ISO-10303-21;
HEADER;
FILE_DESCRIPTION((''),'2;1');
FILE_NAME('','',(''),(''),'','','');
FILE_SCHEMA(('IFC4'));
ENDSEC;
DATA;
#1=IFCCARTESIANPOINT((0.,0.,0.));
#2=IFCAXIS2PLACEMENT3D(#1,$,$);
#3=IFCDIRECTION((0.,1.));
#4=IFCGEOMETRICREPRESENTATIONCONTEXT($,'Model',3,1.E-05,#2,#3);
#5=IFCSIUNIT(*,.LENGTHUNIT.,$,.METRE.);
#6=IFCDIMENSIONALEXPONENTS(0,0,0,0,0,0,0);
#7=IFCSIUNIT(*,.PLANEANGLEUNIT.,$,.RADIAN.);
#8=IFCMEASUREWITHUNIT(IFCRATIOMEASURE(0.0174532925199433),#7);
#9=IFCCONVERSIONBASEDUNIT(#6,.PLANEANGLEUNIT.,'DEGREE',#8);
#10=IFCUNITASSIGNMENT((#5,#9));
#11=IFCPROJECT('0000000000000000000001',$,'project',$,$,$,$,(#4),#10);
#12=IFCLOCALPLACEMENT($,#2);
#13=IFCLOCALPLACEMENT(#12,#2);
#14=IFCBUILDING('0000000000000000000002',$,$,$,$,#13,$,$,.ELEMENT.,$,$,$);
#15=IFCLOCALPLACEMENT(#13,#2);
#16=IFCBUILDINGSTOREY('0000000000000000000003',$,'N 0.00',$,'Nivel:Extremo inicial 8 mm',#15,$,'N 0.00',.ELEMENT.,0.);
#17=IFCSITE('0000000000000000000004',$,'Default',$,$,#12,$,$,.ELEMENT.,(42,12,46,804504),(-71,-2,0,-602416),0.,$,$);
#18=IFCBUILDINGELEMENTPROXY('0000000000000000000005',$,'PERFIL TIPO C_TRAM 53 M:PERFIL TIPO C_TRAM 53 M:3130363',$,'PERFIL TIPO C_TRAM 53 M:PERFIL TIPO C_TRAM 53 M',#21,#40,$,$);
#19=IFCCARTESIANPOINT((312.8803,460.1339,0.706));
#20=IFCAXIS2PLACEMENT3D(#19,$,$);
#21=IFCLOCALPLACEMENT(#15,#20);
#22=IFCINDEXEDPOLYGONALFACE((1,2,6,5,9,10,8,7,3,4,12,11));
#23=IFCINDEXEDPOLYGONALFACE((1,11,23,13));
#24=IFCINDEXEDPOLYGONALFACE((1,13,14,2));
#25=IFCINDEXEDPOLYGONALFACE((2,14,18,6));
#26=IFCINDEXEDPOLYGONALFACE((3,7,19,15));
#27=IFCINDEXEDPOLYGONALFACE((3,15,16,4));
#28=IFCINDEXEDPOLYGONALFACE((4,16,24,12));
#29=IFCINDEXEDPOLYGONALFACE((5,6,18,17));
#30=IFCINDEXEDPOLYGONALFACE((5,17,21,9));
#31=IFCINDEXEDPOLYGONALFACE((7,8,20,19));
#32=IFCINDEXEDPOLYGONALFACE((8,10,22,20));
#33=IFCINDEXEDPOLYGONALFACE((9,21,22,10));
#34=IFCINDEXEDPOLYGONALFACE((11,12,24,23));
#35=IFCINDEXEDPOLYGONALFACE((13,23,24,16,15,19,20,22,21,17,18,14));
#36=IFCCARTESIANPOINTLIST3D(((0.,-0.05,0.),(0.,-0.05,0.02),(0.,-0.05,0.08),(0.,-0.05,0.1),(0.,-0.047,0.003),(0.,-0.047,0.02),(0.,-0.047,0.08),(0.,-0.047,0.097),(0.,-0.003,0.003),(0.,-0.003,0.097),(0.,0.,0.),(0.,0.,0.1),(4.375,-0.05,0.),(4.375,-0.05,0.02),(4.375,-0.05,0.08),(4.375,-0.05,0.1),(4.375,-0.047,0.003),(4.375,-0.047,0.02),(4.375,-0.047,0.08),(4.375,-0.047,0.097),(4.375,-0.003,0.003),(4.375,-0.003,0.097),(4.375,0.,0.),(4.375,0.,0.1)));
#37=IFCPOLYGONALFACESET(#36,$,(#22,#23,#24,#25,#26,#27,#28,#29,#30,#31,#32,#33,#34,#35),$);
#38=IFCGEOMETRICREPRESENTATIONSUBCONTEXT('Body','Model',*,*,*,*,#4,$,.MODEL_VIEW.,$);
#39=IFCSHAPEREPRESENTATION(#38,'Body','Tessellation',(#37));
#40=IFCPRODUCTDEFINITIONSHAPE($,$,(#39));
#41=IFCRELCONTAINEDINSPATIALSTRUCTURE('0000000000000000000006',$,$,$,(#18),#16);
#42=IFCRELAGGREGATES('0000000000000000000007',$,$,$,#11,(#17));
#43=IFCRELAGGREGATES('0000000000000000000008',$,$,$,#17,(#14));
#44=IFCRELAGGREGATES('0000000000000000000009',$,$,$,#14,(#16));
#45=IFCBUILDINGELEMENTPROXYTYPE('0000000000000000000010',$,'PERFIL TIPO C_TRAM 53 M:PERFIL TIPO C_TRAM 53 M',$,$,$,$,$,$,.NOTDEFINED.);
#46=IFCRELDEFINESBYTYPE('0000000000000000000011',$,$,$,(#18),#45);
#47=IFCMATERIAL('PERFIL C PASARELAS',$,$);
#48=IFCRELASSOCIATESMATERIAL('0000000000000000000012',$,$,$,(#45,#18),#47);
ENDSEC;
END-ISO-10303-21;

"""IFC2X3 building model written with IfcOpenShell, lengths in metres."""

from ifc_helpers import new_model, entity, si_unit, converted_unit, direction, frame, origin, place, context, subcontext, project, spatial, polyline, outline, extrude, source, transform, mapped, material, type_object, type_shapes, element, save


model = new_model("IFC2X3")

# Units and contexts
model_context = context("Model", 3, precision=1e-05, world=origin(), true_north=direction((0.0, 1.0)))
body_context = subcontext(model_context, "Body", "Model", "MODEL_VIEW")
ifc_project = project(units=[si_unit("LENGTHUNIT", "METRE"), converted_unit("PLANEANGLEUNIT", "DEGREE", entity("IfcRatioMeasure", 0.0174532925199433), si_unit("PLANEANGLEUNIT", "RADIAN"), dimensions=[0, 0, 0, 0, 0, 0, 0])], contexts=[model_context])

# Site, building, storey
site_placement = place(None, origin())
site = spatial("IfcSite", under=ifc_project, at=site_placement, Name="Default", CompositionType="ELEMENT", RefLatitude=(42, 12, 46, 804504), RefLongitude=(-71, -2, 0, -602416), RefElevation=0.0)
building_placement = place(site_placement, origin())
building = spatial("IfcBuilding", under=site, at=building_placement, CompositionType="ELEMENT")
storey_placement = place(building_placement, origin())
storey = spatial("IfcBuildingStorey", under=building, at=storey_placement, Name="N 0.00", ObjectType="Nivel:Extremo inicial 8 mm", LongName="N 0.00", CompositionType="ELEMENT", Elevation=0.0)

# Building element proxy
ifc_material_1 = material(Name="PERFIL C PASARELAS")
building_element_proxy_type_1 = type_object("IfcBuildingElementProxyType", Name="PERFIL TIPO C_TRAM 53 M:PERFIL TIPO C_TRAM 53 M", PredefinedType="NOTDEFINED", material=ifc_material_1)
shared_shape_1 = source(origin(), body_context, "Body", "SweptSolid", [
    extrude(outline(polyline([(0.03, -0.0172), (0.05, -0.0172), (0.05, 0.0328), (-0.05, 0.0328), (-0.05, -0.0172), (-0.03, -0.0172), (-0.03, -0.0142), (-0.047, -0.0142), (-0.047, 0.0298), (0.047, 0.0298), (0.047, -0.0142), (0.03, -0.0142), (0.03, -0.0172)])), frame((0.0, -0.0328, 0.05), z_axis=(1.0, 0.0, 0.0), x_axis=(0.0, 0.0, -1.0)), (0.0, 0.0, 1.0), 4.375),
])
type_shapes(building_element_proxy_type_1, [shared_shape_1])
proxy_1_placement = place(storey_placement, frame((312.8803, 460.1339, 0.706)))
element("IfcBuildingElementProxy", 1, at=proxy_1_placement, inside=storey, type_object=building_element_proxy_type_1, material=ifc_material_1, Name="PERFIL TIPO C_TRAM 53 M:PERFIL TIPO C_TRAM 53 M:3130363", ObjectType="PERFIL TIPO C_TRAM 53 M:PERFIL TIPO C_TRAM 53 M", context=body_context, shape_type="MappedRepresentation", body=[
    mapped(shared_shape_1, transform((0.0, 0.0, 0.0), scale=1.0)),
])

save(model, "model.ifc")
